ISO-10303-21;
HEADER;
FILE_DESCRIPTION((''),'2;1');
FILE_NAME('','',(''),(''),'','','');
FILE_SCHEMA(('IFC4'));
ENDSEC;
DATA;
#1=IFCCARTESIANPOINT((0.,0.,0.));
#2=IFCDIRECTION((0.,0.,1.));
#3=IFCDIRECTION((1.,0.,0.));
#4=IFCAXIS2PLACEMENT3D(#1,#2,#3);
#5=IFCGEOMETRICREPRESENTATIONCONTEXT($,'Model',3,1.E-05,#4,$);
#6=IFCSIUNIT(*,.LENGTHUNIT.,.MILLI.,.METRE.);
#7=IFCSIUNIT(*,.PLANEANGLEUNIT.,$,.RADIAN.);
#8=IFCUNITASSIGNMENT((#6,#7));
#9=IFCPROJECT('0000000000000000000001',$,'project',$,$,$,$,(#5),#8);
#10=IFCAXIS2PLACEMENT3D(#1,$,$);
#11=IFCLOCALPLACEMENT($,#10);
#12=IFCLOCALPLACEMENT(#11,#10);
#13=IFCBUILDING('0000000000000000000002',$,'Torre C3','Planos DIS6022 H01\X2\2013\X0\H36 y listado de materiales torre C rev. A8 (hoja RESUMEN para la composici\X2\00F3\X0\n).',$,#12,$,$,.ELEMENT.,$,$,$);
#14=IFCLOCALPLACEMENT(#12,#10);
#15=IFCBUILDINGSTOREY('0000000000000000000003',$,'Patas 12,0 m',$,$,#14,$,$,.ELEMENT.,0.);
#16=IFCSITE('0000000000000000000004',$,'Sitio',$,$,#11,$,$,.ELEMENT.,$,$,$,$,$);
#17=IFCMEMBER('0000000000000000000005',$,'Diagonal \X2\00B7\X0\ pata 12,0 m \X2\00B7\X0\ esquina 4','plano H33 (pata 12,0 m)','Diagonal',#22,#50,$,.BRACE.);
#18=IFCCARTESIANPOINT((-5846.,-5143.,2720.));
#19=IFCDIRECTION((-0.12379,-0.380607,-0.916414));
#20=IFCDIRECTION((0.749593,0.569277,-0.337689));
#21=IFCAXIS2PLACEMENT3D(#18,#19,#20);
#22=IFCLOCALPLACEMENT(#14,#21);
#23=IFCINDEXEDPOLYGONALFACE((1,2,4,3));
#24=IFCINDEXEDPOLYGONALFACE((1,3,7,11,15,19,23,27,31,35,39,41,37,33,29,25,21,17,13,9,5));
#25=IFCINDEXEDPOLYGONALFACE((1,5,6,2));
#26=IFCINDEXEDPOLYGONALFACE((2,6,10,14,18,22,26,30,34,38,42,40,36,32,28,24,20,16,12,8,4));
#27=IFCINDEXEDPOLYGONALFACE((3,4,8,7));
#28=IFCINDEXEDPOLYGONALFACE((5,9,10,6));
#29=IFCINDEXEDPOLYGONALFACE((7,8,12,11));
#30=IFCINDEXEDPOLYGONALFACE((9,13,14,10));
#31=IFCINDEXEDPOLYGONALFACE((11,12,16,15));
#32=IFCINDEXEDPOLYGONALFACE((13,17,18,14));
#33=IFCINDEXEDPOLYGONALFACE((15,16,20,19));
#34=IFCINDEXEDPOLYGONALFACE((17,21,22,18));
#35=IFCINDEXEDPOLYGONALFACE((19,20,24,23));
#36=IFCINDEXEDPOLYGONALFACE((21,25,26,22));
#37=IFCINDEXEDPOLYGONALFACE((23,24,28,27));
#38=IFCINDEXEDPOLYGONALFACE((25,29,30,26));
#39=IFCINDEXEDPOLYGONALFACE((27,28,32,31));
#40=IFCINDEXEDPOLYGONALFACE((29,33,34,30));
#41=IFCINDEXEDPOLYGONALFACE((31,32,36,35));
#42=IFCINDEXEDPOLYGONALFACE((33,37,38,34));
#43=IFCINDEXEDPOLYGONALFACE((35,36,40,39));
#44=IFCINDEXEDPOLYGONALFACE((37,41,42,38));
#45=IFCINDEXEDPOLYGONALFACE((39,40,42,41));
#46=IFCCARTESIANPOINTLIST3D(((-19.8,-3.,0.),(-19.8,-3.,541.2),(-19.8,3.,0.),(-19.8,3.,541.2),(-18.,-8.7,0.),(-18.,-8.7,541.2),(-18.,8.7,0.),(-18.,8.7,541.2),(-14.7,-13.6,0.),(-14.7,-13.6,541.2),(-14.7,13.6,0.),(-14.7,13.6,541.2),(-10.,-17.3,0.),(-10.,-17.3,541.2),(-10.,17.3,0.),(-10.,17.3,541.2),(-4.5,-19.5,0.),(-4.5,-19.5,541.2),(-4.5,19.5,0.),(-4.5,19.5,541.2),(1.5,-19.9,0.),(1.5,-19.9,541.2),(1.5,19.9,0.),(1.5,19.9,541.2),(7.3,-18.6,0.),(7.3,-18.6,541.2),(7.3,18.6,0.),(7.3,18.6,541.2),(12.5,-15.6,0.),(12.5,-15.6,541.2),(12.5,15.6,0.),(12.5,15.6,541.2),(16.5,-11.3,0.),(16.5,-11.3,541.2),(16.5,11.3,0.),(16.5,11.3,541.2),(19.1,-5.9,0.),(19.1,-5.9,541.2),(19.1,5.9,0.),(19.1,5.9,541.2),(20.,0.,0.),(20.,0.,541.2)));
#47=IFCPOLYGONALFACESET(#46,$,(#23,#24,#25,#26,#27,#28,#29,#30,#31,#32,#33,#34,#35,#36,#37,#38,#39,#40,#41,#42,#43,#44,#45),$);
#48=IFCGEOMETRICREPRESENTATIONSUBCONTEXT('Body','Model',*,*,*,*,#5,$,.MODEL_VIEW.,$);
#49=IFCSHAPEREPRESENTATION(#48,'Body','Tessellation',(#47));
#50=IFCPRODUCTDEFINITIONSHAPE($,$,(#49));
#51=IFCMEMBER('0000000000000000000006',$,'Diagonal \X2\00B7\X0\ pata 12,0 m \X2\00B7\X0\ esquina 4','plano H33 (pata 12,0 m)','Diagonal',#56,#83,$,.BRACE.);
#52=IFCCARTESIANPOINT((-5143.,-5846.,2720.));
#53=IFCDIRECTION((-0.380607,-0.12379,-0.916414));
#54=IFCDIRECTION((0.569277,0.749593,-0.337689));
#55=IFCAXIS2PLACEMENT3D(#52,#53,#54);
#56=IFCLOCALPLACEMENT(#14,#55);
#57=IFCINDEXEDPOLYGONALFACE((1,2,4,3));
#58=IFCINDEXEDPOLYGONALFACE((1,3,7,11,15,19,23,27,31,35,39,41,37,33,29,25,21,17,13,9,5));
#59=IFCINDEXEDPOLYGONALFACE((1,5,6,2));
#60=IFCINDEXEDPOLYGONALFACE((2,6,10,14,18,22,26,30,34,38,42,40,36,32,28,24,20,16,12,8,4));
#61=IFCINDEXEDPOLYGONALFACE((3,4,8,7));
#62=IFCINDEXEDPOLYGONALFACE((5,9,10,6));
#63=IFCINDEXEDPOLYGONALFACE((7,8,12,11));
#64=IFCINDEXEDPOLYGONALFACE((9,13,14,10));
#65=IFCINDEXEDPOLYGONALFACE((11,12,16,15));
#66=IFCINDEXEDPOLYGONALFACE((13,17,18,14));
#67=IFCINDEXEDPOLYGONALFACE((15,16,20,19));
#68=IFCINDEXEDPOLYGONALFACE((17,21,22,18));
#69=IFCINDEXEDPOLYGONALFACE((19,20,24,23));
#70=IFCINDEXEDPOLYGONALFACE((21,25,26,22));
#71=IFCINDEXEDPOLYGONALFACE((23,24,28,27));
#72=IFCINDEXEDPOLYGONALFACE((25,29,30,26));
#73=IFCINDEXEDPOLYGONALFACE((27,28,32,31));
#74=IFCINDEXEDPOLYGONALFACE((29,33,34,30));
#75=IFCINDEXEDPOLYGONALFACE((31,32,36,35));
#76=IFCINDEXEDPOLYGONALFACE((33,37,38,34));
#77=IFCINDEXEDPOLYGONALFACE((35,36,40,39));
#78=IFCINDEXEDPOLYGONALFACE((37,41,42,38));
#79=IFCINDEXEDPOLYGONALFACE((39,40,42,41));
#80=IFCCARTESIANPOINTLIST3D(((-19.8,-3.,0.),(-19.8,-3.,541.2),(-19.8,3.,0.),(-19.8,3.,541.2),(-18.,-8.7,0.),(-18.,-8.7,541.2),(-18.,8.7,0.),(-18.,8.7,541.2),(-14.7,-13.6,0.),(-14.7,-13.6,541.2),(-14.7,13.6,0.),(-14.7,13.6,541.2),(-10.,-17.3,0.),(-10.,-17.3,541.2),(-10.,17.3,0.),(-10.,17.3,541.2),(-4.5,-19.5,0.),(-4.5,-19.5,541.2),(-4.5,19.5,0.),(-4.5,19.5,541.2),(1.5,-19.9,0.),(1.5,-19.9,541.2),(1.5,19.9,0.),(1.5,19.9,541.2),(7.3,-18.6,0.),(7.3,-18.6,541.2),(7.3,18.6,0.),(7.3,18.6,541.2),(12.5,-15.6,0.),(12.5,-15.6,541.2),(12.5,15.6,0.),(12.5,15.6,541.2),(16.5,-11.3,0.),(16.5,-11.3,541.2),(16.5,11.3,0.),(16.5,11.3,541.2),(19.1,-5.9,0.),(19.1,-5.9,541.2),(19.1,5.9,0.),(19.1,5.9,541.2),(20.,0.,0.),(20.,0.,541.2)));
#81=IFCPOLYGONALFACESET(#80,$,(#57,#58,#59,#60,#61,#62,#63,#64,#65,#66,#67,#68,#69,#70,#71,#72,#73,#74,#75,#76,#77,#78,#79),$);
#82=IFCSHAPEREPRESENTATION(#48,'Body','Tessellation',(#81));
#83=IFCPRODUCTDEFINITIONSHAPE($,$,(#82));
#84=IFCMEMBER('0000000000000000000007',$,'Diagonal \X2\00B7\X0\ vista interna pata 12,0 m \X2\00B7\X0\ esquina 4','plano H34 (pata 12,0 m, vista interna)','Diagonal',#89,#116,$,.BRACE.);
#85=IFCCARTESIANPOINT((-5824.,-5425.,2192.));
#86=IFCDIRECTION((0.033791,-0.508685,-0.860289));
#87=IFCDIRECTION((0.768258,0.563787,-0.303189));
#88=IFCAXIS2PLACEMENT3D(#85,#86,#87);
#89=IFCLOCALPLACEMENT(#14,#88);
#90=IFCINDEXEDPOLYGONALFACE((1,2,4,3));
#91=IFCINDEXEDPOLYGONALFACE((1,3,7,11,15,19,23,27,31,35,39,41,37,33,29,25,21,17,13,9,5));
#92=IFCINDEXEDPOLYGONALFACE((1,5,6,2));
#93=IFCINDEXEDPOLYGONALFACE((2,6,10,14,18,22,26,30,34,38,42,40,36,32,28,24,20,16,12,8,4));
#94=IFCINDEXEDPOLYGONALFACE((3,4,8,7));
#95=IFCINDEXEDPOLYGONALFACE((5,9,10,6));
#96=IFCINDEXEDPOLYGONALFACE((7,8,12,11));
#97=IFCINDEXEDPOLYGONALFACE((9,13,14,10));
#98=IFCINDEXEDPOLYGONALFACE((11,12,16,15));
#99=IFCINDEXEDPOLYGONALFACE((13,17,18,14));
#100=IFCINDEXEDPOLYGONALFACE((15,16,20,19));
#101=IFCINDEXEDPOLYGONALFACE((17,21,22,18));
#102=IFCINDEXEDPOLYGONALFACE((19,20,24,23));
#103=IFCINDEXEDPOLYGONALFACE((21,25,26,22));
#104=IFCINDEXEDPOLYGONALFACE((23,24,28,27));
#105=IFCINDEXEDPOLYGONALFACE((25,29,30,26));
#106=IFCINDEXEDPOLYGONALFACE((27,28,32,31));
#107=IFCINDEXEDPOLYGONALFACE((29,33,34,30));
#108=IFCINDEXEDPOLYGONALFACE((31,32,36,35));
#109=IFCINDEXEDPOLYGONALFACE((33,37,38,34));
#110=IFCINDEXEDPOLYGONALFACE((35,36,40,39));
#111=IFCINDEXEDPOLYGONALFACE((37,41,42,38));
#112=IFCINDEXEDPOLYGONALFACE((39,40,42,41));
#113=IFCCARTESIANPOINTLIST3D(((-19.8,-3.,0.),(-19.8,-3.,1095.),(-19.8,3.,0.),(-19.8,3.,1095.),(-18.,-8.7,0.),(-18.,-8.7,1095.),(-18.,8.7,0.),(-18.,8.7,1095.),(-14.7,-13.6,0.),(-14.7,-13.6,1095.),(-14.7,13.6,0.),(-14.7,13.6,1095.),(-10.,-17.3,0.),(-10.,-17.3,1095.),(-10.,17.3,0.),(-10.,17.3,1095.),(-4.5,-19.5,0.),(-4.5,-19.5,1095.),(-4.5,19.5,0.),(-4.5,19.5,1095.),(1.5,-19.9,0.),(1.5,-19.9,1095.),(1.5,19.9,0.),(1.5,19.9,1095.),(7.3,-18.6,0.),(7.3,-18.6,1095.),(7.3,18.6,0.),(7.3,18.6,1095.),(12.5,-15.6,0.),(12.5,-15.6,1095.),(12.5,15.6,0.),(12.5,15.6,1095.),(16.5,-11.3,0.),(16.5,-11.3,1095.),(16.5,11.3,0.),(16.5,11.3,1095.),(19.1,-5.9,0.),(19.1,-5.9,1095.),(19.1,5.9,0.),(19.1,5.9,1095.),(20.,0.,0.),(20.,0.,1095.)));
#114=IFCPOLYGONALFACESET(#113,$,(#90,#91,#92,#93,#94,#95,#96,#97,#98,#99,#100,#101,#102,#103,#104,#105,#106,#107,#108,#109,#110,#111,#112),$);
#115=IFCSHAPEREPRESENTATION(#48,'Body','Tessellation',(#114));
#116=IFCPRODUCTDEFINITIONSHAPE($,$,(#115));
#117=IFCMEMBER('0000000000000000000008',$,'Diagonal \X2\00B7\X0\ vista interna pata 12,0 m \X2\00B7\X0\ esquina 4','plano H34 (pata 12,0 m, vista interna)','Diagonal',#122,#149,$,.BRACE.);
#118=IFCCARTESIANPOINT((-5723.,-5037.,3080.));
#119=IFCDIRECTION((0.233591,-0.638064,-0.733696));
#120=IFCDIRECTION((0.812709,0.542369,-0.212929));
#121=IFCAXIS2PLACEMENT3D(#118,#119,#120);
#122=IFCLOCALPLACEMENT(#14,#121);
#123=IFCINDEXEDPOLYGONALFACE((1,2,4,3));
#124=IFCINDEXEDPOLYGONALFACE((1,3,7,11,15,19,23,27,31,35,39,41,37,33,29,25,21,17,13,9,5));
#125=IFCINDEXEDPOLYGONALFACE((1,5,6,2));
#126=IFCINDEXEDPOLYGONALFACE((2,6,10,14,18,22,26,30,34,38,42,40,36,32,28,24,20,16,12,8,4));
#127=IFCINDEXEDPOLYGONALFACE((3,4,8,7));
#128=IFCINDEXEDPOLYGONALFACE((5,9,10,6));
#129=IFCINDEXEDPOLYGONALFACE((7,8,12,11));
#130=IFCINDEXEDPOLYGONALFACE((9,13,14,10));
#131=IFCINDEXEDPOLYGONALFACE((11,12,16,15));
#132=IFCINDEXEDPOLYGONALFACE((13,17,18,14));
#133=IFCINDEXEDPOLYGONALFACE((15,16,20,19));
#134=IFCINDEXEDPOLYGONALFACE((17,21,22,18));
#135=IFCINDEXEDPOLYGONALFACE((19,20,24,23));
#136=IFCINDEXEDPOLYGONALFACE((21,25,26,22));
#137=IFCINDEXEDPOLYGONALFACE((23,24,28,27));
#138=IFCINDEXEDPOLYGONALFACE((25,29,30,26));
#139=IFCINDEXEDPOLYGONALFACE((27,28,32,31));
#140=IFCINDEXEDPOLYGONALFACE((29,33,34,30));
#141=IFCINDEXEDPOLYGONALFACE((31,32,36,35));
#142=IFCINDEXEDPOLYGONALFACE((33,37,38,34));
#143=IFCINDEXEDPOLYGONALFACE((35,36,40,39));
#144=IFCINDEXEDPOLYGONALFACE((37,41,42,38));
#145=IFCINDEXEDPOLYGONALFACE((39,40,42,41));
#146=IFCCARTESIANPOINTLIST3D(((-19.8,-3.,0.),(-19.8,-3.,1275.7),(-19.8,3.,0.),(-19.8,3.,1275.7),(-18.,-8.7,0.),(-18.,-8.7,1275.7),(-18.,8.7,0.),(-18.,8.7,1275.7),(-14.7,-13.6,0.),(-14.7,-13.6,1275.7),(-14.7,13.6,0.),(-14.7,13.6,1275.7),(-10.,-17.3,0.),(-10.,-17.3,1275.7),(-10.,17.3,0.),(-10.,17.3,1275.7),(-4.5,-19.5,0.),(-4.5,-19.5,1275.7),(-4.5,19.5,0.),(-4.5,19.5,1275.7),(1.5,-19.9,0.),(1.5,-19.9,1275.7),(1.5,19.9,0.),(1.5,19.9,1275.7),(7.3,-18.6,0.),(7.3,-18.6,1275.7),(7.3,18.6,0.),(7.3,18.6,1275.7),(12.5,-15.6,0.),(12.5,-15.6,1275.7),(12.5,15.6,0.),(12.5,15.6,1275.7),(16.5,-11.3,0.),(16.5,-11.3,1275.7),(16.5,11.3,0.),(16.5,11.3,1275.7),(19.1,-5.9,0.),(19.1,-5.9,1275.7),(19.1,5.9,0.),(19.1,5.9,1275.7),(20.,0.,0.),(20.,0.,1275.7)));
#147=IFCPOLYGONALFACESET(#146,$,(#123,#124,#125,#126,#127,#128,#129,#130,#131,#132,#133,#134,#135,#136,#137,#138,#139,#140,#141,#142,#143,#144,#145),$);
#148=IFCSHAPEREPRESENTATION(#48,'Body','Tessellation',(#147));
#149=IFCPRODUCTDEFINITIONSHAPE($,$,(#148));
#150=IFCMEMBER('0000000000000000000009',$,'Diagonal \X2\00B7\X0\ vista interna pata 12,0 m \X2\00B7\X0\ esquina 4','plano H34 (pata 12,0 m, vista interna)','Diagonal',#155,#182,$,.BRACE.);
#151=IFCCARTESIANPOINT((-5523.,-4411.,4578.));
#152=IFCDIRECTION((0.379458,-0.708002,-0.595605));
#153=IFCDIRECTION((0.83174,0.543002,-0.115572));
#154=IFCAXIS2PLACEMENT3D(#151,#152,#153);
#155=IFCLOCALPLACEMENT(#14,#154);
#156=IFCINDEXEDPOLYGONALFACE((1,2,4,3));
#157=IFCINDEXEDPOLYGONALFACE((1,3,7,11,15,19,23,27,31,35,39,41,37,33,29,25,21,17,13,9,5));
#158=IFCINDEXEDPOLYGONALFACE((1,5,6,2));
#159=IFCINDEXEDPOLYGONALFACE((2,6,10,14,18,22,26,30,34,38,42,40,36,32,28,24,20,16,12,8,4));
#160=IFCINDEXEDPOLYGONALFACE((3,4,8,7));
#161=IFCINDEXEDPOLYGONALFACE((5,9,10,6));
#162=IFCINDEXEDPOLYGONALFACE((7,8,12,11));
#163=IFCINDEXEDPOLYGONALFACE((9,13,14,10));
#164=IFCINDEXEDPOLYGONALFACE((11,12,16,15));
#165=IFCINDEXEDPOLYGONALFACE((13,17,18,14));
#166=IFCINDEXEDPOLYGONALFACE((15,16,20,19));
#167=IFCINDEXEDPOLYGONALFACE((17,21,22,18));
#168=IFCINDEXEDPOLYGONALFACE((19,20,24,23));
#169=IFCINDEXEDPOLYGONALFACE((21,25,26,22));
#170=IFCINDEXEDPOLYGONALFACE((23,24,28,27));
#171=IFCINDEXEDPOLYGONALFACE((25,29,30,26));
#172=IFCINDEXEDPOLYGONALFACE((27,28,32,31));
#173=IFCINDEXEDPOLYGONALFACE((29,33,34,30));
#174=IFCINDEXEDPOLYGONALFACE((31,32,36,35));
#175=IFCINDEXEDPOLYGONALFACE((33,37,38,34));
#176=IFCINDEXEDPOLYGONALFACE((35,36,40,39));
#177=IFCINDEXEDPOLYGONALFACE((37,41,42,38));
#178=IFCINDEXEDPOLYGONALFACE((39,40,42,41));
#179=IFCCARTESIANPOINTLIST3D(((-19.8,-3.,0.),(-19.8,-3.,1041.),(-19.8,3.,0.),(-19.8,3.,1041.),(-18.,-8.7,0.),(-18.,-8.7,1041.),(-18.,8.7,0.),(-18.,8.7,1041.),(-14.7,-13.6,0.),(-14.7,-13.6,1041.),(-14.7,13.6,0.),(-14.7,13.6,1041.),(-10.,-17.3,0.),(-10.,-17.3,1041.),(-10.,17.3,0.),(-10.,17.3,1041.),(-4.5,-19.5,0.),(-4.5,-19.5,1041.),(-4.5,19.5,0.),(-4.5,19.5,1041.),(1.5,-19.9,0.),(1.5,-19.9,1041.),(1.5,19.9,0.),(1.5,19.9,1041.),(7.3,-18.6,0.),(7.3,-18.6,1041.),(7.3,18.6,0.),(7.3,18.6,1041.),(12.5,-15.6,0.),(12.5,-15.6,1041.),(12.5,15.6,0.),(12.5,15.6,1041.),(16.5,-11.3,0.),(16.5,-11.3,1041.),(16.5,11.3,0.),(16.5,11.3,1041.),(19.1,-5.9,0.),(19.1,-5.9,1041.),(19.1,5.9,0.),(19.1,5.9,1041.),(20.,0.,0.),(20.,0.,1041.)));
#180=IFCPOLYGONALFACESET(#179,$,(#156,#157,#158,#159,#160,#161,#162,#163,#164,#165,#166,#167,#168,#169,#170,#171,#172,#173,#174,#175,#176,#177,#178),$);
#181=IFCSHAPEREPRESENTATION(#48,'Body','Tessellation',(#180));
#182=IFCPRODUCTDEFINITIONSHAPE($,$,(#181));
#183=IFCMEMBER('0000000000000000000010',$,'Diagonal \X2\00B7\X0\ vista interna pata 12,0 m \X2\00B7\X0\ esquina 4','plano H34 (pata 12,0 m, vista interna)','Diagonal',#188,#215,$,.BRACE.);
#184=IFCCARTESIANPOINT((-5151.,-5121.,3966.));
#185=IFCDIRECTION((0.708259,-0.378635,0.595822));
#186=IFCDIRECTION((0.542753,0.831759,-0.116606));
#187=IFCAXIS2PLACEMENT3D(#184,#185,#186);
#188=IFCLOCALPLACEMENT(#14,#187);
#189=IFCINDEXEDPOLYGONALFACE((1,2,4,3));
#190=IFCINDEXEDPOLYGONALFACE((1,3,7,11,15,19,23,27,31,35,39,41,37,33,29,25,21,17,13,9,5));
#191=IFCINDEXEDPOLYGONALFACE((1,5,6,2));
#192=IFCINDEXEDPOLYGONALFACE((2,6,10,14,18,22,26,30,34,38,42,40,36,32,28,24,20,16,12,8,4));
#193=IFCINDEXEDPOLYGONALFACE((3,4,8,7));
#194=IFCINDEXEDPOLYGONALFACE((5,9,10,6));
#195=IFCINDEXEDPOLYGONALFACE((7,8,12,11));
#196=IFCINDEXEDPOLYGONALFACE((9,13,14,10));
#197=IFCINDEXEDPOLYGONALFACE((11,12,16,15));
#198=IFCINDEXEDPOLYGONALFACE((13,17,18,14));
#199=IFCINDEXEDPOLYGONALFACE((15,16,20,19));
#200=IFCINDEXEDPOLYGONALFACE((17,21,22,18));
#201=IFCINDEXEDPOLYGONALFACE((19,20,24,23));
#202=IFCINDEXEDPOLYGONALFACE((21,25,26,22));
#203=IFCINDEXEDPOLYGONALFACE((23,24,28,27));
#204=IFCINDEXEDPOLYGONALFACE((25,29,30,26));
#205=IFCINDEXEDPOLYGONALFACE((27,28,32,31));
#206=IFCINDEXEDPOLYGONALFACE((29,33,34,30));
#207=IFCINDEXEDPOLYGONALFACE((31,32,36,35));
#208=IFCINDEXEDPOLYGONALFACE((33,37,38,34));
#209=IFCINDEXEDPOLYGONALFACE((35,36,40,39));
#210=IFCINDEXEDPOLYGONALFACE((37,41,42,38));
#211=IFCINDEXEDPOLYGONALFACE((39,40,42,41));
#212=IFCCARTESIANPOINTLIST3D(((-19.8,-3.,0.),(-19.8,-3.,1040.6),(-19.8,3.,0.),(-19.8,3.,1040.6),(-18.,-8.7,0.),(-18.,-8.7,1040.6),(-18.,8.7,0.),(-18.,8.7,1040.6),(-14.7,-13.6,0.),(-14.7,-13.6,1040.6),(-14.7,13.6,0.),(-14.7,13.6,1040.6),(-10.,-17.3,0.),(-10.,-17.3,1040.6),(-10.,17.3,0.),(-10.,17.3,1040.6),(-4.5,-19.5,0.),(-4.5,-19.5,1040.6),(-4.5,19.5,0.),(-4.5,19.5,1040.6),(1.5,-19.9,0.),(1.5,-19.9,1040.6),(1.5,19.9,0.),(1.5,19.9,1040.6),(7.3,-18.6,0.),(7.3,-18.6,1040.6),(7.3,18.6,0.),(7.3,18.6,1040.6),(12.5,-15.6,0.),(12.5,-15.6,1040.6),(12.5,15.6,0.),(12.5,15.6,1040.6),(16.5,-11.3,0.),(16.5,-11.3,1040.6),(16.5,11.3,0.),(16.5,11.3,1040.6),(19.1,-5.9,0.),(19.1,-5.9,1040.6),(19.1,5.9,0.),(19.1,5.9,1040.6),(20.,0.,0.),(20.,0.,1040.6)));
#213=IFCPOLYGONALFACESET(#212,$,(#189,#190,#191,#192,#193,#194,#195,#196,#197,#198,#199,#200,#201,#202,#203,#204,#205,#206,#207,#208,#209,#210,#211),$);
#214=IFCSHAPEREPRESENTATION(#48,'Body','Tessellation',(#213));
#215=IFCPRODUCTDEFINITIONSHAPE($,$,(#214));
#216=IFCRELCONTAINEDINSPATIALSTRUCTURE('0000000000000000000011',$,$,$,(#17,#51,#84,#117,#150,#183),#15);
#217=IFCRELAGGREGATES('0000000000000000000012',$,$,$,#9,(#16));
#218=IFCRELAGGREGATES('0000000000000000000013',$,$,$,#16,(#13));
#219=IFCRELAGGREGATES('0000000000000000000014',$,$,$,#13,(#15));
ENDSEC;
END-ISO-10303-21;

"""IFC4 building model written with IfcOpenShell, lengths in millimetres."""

from ifc_helpers import new_model, si_unit, frame, origin, origin_with_axes, place, context, subcontext, project, spatial, circle, extrude, element, save


model = new_model("IFC4")

# Units and contexts
model_context = context("Model", 3, precision=1e-05, world=origin_with_axes())
body_context = subcontext(model_context, "Body", "Model", "MODEL_VIEW")
ifc_project = project(units=[si_unit("LENGTHUNIT", "METRE", prefix="MILLI"), si_unit("PLANEANGLEUNIT", "RADIAN")], contexts=[model_context])

# Site, building, storey
site_placement = place(None, origin())
site = spatial("IfcSite", under=ifc_project, at=site_placement, Name="Sitio", CompositionType="ELEMENT")
building_placement = place(site_placement, origin())
building = spatial("IfcBuilding", under=site, at=building_placement, Name="Torre C3", Description="Planos DIS6022 H01–H36 y listado de materiales torre C rev. A8 (hoja RESUMEN para la composición).", CompositionType="ELEMENT")
storey_placement = place(building_placement, origin())
storey = spatial("IfcBuildingStorey", under=building, at=storey_placement, Name="Patas 12,0 m", CompositionType="ELEMENT", Elevation=0.0)

# Members
for number, where, z_axis, x_axis, name in (
    (1, (-5846.0, -5143.0, 2720.0), (-0.12379, -0.380607, -0.916414), (0.749593, 0.569277, -0.337689), "Diagonal · pata 12,0 m · esquina 4"),
    (2, (-5143.0, -5846.0, 2720.0), (-0.380607, -0.12379, -0.916414), (0.569277, 0.749593, -0.337689), "Diagonal · pata 12,0 m · esquina 4"),
):
    element("IfcMember", number, at=place(storey_placement, frame(where, z_axis=z_axis, x_axis=x_axis)), inside=storey, Name=name, Description="plano H33 (pata 12,0 m)", ObjectType="Diagonal", PredefinedType="BRACE", context=body_context, shape_type="SweptSolid", body=[
        extrude(circle(Radius=20.0), None, (0.0, 0.0, 1.0), 541.2),
    ])
member_1_placement = place(storey_placement, frame((-5824.0, -5425.0, 2192.0), z_axis=(0.033791, -0.508685, -0.860289), x_axis=(0.768258, 0.563787, -0.303189)))
element("IfcMember", 3, at=member_1_placement, inside=storey, Name="Diagonal · vista interna pata 12,0 m · esquina 4", Description="plano H34 (pata 12,0 m, vista interna)", ObjectType="Diagonal", PredefinedType="BRACE", context=body_context, shape_type="SweptSolid", body=[
    extrude(circle(Radius=20.0), None, (0.0, 0.0, 1.0), 1095.0),
])
member_2_placement = place(storey_placement, frame((-5723.0, -5037.0, 3080.0), z_axis=(0.233591, -0.638064, -0.733696), x_axis=(0.812709, 0.542369, -0.212929)))
element("IfcMember", 4, at=member_2_placement, inside=storey, Name="Diagonal · vista interna pata 12,0 m · esquina 4", Description="plano H34 (pata 12,0 m, vista interna)", ObjectType="Diagonal", PredefinedType="BRACE", context=body_context, shape_type="SweptSolid", body=[
    extrude(circle(Radius=20.0), None, (0.0, 0.0, 1.0), 1275.7),
])
member_3_placement = place(storey_placement, frame((-5523.0, -4411.0, 4578.0), z_axis=(0.379458, -0.708002, -0.595605), x_axis=(0.83174, 0.543002, -0.115572)))
element("IfcMember", 5, at=member_3_placement, inside=storey, Name="Diagonal · vista interna pata 12,0 m · esquina 4", Description="plano H34 (pata 12,0 m, vista interna)", ObjectType="Diagonal", PredefinedType="BRACE", context=body_context, shape_type="SweptSolid", body=[
    extrude(circle(Radius=20.0), None, (0.0, 0.0, 1.0), 1041.0),
])
member_4_placement = place(storey_placement, frame((-5151.0, -5121.0, 3966.0), z_axis=(0.708259, -0.378635, 0.595822), x_axis=(0.542753, 0.831759, -0.116606)))
element("IfcMember", 6, at=member_4_placement, inside=storey, Name="Diagonal · vista interna pata 12,0 m · esquina 4", Description="plano H34 (pata 12,0 m, vista interna)", ObjectType="Diagonal", PredefinedType="BRACE", context=body_context, shape_type="SweptSolid", body=[
    extrude(circle(Radius=20.0), None, (0.0, 0.0, 1.0), 1040.6),
])

save(model, "model.ifc")
